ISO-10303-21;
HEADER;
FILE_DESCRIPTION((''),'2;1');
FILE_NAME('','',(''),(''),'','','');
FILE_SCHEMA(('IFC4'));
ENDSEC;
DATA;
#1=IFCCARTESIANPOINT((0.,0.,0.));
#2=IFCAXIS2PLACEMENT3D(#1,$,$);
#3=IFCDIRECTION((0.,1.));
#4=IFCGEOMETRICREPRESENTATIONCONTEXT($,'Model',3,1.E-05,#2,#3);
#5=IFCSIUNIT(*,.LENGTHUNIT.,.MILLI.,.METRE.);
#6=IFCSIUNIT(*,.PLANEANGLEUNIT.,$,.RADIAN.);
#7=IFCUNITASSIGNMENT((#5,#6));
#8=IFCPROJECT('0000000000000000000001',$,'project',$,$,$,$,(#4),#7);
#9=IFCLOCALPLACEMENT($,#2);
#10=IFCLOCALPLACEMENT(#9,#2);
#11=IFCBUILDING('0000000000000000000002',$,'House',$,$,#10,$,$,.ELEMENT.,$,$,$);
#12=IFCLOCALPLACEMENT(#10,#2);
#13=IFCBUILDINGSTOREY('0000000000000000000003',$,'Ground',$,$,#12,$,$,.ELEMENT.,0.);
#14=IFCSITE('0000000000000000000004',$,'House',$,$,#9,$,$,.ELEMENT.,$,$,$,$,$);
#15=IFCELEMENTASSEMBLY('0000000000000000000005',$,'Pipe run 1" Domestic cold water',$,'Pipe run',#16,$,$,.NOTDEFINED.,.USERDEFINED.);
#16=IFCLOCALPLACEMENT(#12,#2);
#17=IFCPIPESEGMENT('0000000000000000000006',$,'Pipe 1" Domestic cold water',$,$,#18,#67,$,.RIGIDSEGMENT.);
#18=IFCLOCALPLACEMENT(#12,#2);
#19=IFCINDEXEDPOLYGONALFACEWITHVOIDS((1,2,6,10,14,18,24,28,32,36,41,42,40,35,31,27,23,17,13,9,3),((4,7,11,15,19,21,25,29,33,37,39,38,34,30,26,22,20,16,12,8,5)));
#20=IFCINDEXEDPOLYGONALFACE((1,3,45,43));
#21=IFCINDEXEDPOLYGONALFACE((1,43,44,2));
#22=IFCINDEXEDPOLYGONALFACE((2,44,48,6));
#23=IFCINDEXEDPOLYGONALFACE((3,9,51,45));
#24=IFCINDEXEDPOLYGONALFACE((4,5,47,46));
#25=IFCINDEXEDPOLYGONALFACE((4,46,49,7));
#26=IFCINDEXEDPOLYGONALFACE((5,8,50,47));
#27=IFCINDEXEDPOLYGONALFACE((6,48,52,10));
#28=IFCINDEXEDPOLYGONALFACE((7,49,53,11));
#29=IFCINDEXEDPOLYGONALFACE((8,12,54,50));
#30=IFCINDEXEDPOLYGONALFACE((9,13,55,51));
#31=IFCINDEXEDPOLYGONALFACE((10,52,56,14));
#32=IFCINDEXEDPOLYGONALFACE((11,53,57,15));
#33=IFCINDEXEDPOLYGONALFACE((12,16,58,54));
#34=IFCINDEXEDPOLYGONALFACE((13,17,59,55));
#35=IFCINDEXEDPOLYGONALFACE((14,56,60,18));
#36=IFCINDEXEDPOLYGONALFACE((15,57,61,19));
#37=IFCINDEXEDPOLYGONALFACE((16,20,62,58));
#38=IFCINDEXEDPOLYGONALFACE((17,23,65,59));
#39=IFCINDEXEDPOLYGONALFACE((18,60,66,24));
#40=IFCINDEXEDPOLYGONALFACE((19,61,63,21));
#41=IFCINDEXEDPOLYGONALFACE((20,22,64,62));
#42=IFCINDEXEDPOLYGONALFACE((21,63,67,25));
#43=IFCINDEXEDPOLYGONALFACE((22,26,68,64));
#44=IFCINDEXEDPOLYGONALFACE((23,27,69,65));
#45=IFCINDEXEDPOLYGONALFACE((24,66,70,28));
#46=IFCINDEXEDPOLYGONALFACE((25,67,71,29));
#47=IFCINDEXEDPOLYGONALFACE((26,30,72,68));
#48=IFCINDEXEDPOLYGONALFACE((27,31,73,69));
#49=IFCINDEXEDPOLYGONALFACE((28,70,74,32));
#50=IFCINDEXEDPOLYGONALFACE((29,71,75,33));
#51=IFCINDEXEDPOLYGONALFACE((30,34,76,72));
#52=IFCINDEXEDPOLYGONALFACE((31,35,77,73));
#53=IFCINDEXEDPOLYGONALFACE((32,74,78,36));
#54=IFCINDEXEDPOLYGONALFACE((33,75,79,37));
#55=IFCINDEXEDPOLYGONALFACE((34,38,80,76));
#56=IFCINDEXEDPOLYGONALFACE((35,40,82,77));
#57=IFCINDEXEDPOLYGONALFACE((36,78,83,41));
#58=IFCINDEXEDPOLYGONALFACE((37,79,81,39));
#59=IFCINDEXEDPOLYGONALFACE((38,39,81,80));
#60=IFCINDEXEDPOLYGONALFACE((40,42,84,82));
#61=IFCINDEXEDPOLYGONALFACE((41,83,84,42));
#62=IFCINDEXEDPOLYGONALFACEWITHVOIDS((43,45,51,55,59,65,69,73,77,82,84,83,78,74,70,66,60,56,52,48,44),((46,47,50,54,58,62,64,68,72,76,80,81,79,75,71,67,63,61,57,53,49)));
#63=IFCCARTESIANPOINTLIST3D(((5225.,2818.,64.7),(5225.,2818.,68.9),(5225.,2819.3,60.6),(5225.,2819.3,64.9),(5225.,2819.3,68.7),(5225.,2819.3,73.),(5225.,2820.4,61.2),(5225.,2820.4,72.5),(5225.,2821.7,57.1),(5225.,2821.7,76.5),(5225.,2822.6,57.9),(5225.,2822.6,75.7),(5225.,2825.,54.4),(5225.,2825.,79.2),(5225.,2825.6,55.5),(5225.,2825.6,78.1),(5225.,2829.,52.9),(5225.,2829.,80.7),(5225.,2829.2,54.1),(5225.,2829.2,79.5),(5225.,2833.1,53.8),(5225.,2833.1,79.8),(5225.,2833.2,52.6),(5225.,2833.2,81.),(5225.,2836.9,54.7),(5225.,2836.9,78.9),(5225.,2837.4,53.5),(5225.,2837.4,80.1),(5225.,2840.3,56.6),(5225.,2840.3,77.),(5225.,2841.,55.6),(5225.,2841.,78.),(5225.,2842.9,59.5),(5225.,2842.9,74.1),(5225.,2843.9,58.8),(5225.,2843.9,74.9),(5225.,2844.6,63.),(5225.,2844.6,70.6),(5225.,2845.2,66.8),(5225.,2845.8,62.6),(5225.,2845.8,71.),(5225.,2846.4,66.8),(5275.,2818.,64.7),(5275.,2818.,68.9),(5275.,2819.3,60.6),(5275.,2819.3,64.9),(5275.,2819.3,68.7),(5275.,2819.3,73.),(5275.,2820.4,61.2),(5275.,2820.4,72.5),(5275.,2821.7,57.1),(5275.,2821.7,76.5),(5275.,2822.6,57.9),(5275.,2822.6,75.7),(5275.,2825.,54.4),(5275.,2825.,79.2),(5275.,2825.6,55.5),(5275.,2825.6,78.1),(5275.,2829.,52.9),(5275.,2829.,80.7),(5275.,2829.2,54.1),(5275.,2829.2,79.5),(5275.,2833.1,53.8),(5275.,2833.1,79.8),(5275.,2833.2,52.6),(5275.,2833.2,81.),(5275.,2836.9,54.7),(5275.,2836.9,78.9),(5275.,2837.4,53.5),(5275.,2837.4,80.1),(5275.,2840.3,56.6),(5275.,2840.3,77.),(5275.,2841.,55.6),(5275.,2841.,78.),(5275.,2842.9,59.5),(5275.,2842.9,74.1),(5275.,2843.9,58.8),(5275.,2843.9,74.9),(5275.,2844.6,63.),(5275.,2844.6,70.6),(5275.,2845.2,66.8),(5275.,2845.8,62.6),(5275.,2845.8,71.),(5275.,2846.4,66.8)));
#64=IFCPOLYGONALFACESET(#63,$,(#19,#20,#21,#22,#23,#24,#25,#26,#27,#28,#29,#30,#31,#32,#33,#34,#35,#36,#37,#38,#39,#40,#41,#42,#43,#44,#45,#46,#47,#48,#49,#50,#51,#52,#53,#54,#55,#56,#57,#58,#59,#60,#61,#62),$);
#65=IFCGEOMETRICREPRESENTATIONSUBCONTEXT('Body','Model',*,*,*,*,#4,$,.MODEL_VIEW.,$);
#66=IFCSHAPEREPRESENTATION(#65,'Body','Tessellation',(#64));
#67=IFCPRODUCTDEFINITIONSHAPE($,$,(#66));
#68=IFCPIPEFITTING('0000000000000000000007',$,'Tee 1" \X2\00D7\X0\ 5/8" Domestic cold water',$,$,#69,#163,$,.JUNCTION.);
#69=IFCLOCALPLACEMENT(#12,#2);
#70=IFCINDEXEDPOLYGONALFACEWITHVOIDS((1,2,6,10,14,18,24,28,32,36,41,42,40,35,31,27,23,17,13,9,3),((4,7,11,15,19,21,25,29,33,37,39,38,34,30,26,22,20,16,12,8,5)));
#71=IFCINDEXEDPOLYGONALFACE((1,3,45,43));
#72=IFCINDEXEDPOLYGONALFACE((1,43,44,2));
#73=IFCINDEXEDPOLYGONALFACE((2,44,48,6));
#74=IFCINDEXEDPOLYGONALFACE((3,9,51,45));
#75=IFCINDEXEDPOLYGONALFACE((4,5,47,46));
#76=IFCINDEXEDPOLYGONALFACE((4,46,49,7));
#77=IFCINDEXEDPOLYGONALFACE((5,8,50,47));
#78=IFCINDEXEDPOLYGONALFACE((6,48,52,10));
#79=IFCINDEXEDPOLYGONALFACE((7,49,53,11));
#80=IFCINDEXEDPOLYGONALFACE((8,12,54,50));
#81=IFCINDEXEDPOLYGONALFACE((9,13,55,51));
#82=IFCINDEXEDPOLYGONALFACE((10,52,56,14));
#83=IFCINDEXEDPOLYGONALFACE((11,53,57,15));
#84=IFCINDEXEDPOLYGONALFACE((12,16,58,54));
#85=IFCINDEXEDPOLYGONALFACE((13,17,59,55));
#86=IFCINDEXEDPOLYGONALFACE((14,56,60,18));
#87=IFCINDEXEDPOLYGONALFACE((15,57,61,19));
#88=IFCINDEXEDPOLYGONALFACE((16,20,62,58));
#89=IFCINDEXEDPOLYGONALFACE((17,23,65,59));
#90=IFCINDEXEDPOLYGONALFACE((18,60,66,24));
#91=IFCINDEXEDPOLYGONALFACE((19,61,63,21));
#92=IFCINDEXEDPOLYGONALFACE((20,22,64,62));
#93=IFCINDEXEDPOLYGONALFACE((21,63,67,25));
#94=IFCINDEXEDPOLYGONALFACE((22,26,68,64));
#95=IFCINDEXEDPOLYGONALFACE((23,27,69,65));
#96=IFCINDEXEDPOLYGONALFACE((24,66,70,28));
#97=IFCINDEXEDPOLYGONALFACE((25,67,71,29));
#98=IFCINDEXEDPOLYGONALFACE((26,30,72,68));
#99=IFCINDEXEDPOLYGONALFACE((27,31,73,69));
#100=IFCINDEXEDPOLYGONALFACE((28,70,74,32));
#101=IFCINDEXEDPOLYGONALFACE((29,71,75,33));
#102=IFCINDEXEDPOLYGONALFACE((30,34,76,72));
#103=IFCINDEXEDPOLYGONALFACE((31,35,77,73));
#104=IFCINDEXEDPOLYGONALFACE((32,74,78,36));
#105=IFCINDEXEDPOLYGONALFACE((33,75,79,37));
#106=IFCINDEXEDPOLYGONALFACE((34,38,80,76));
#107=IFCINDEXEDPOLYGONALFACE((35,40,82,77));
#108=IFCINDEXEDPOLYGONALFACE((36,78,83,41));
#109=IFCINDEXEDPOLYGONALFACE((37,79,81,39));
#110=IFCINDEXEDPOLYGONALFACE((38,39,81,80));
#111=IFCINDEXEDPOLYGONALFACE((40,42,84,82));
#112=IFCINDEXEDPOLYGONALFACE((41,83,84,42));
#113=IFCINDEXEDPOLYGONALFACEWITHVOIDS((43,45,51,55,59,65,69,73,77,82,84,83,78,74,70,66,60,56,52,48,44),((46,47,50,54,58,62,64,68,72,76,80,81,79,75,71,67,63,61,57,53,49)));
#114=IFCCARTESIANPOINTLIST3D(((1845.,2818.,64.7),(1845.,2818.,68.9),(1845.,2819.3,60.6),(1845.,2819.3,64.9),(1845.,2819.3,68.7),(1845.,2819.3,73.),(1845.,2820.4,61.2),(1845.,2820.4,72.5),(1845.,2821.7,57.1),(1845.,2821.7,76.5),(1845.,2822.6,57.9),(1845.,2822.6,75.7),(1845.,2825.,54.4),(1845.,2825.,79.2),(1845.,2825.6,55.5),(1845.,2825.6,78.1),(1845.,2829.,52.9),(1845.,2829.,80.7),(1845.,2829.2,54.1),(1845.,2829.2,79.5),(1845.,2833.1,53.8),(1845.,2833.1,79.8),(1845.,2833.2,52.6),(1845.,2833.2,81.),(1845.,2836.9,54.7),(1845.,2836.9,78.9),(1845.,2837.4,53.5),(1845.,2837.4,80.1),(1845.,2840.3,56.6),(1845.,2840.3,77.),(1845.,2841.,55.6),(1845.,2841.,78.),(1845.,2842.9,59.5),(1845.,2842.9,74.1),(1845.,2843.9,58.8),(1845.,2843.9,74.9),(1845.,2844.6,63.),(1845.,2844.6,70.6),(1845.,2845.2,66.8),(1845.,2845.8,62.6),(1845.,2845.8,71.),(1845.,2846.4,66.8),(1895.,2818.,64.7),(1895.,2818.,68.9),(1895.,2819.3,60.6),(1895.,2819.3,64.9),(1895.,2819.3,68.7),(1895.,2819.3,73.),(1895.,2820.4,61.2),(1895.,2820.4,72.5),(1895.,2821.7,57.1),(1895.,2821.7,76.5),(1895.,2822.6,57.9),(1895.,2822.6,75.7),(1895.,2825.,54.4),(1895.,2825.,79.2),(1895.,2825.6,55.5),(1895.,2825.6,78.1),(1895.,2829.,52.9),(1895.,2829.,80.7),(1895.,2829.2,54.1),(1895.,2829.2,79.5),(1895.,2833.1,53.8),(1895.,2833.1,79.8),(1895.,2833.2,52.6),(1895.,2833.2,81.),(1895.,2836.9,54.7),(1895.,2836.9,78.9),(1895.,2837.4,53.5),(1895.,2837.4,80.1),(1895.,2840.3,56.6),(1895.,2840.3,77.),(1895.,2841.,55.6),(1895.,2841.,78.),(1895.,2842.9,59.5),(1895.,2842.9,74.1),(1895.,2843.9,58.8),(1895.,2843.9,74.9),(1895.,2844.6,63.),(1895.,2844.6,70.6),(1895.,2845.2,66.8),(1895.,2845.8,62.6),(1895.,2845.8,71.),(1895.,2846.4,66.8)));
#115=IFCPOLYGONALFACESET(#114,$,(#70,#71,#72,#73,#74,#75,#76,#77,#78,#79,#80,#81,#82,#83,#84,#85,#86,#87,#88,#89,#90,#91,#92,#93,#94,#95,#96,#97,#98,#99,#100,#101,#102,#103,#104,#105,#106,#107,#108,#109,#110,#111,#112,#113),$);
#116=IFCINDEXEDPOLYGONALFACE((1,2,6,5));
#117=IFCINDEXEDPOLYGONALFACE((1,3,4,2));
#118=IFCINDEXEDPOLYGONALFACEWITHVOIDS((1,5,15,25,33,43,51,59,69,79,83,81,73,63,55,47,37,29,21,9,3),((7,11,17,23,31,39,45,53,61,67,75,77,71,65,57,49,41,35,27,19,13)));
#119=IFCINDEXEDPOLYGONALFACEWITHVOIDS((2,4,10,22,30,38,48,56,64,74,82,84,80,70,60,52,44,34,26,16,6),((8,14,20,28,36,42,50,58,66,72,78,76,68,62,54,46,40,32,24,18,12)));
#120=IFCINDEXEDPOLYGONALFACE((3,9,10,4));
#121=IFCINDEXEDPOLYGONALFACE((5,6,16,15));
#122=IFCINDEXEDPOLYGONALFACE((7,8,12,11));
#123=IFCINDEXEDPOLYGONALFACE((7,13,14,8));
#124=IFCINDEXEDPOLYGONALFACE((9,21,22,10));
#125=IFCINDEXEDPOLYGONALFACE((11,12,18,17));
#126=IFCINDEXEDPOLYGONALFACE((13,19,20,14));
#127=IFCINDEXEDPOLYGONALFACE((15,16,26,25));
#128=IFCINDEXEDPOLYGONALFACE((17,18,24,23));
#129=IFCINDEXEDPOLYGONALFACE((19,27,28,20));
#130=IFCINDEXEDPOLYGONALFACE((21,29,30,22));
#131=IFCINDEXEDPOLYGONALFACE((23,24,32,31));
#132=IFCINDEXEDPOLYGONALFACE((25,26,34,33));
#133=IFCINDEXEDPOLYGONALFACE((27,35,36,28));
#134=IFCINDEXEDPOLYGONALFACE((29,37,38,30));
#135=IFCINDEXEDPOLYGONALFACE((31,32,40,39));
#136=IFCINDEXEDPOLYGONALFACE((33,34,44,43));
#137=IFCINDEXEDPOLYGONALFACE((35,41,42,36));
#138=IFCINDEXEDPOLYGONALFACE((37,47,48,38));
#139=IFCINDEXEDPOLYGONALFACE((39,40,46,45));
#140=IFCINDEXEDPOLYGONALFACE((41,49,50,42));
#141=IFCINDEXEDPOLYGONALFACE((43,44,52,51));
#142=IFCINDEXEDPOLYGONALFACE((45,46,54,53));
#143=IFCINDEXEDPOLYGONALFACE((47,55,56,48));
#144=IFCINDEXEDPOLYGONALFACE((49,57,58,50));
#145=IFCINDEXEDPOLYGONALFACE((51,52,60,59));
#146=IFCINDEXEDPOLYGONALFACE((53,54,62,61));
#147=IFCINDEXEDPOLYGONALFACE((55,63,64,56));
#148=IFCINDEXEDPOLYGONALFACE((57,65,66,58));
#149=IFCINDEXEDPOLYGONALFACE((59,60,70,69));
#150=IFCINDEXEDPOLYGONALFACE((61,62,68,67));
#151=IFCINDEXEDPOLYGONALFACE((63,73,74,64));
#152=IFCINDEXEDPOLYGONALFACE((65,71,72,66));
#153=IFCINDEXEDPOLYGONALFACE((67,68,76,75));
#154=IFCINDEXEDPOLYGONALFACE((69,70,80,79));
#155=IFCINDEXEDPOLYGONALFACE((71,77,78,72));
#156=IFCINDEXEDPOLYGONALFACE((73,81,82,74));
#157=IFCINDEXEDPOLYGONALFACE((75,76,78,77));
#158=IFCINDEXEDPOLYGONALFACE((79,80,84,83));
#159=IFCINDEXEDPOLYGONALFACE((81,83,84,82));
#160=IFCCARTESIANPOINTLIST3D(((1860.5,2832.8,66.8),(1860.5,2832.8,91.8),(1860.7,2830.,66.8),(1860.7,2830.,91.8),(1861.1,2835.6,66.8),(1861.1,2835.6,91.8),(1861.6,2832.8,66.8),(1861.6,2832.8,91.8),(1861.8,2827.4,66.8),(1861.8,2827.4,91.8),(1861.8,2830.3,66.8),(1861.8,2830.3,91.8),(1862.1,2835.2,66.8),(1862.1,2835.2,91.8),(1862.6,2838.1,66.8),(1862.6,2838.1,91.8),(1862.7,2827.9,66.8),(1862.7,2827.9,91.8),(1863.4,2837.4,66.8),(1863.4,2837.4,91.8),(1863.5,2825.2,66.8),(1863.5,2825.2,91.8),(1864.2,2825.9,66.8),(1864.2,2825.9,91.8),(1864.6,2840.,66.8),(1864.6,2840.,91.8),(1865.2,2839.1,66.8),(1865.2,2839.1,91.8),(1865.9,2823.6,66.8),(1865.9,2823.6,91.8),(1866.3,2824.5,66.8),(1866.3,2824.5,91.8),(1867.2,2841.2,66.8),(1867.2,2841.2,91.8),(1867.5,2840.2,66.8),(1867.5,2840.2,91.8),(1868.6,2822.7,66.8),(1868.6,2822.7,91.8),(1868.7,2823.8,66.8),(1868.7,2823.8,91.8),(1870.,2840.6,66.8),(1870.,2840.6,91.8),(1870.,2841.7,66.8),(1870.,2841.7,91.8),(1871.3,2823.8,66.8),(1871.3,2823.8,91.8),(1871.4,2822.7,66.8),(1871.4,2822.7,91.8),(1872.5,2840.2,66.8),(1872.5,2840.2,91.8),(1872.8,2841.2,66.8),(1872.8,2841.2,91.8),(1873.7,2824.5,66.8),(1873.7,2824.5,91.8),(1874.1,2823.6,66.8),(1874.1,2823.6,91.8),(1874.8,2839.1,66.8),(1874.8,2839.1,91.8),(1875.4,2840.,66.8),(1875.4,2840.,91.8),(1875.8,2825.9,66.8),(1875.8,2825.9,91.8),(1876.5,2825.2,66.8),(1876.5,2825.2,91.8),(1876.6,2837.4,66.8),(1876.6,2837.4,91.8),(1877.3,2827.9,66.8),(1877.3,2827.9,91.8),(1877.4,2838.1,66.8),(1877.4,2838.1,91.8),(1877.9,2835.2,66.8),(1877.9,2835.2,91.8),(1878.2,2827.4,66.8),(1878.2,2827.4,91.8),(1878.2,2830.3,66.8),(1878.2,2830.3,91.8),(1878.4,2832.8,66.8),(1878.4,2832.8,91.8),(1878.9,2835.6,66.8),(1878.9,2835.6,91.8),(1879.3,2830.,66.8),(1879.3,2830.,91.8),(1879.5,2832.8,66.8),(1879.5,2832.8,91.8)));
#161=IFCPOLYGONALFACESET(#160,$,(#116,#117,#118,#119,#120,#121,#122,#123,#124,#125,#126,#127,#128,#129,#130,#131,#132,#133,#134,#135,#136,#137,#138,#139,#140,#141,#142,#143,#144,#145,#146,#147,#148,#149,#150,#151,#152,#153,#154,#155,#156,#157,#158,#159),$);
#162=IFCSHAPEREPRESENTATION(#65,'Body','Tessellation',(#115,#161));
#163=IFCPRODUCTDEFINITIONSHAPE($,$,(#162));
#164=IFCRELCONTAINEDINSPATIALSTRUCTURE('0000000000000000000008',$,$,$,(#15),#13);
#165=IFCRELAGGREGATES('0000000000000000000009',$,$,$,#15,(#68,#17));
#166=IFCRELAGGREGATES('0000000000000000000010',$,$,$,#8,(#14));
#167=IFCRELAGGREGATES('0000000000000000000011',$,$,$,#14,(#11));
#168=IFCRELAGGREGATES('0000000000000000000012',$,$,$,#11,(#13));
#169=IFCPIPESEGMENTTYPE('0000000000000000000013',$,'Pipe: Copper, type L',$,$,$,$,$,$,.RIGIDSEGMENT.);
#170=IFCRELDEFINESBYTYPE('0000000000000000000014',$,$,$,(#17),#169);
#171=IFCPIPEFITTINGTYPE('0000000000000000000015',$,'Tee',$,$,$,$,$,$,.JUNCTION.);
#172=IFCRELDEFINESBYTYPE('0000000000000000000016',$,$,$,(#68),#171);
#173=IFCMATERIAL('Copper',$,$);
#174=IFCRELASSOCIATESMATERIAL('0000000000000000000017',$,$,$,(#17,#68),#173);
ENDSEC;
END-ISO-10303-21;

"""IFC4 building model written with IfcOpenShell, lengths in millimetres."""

from ifc_helpers import new_model, si_unit, direction, frame, origin, origin_with_axes, origin_2d, place, context, subcontext, project, spatial, hollow_circle, extrude, material, type_object, element, aggregate, save


model = new_model("IFC4")

# Units and contexts
model_context = context("Model", 3, precision=1e-05, world=origin(), true_north=direction((0.0, 1.0)))
body_context = subcontext(model_context, "Body", "Model", "MODEL_VIEW")
ifc_project = project(units=[si_unit("LENGTHUNIT", "METRE", prefix="MILLI"), si_unit("PLANEANGLEUNIT", "RADIAN")], contexts=[model_context])

# Site, building, storey
site_placement = place(None, origin())
site = spatial("IfcSite", under=ifc_project, at=site_placement, Name="House", CompositionType="ELEMENT")
building_placement = place(site_placement, origin())
building = spatial("IfcBuilding", under=site, at=building_placement, Name="House", CompositionType="ELEMENT")
storey_placement = place(building_placement, origin())
storey = spatial("IfcBuildingStorey", under=building, at=storey_placement, Name="Ground", CompositionType="ELEMENT", Elevation=0.0)

# Shared definitions
ifc_material = material(Name="Copper")
pipe_segment_type = type_object("IfcPipeSegmentType", Name="Pipe: Copper, type L", PredefinedType="RIGIDSEGMENT")

# Element assembly, pipe segment
assembly_1_placement = place(storey_placement, origin_with_axes())
assembly_1 = element("IfcElementAssembly", 1, at=assembly_1_placement, inside=storey, Name="Pipe run 1\" Domestic cold water", ObjectType="Pipe run", AssemblyPlace="NOTDEFINED", PredefinedType="USERDEFINED")
pipe_segment_1_placement = place(storey_placement, origin_with_axes())
pipe_segment_1 = element("IfcPipeSegment", 2, at=pipe_segment_1_placement, type_object=pipe_segment_type, material=ifc_material, Name="Pipe 1\" Domestic cold water", PredefinedType="RIGIDSEGMENT", context=body_context, shape_type="SweptSolid", body=[
    extrude(hollow_circle(Radius=14.3, WallThickness=1.3, at=origin_2d()), frame((5225.0, 2832.1, 66.8), z_axis=(1.0, 0.0, 0.0), x_axis=(0.0, 1.0, 0.0)), (0.0, 0.0, 1.0), 50.0),
])

# Pipe fitting
pipe_fitting_type_1 = type_object("IfcPipeFittingType", Name="Tee", PredefinedType="JUNCTION")
pipe_fitting_1_placement = place(storey_placement, origin_with_axes())
pipe_fitting_1 = element("IfcPipeFitting", 3, at=pipe_fitting_1_placement, type_object=pipe_fitting_type_1, material=ifc_material, Name="Tee 1\" × 5/8\" Domestic cold water", PredefinedType="JUNCTION", context=body_context, shape_type="SweptSolid", body=[
    extrude(hollow_circle(Radius=14.3, WallThickness=1.3, at=origin_2d()), frame((1845.0, 2832.1, 66.8), z_axis=(1.0, 0.0, 0.0), x_axis=(0.0, 1.0, 0.0)), (0.0, 0.0, 1.0), 50.0),
    extrude(hollow_circle(Radius=9.5, WallThickness=1.1, at=origin_2d()), frame((1870.0, 2832.1, 66.8), z_axis=(0.0, 0.0, 1.0), x_axis=(0.0, 1.0, 0.0)), (0.0, 0.0, 1.0), 25.0),
])
aggregate(assembly_1, [pipe_fitting_1, pipe_segment_1])

save(model, "model.ifc")
